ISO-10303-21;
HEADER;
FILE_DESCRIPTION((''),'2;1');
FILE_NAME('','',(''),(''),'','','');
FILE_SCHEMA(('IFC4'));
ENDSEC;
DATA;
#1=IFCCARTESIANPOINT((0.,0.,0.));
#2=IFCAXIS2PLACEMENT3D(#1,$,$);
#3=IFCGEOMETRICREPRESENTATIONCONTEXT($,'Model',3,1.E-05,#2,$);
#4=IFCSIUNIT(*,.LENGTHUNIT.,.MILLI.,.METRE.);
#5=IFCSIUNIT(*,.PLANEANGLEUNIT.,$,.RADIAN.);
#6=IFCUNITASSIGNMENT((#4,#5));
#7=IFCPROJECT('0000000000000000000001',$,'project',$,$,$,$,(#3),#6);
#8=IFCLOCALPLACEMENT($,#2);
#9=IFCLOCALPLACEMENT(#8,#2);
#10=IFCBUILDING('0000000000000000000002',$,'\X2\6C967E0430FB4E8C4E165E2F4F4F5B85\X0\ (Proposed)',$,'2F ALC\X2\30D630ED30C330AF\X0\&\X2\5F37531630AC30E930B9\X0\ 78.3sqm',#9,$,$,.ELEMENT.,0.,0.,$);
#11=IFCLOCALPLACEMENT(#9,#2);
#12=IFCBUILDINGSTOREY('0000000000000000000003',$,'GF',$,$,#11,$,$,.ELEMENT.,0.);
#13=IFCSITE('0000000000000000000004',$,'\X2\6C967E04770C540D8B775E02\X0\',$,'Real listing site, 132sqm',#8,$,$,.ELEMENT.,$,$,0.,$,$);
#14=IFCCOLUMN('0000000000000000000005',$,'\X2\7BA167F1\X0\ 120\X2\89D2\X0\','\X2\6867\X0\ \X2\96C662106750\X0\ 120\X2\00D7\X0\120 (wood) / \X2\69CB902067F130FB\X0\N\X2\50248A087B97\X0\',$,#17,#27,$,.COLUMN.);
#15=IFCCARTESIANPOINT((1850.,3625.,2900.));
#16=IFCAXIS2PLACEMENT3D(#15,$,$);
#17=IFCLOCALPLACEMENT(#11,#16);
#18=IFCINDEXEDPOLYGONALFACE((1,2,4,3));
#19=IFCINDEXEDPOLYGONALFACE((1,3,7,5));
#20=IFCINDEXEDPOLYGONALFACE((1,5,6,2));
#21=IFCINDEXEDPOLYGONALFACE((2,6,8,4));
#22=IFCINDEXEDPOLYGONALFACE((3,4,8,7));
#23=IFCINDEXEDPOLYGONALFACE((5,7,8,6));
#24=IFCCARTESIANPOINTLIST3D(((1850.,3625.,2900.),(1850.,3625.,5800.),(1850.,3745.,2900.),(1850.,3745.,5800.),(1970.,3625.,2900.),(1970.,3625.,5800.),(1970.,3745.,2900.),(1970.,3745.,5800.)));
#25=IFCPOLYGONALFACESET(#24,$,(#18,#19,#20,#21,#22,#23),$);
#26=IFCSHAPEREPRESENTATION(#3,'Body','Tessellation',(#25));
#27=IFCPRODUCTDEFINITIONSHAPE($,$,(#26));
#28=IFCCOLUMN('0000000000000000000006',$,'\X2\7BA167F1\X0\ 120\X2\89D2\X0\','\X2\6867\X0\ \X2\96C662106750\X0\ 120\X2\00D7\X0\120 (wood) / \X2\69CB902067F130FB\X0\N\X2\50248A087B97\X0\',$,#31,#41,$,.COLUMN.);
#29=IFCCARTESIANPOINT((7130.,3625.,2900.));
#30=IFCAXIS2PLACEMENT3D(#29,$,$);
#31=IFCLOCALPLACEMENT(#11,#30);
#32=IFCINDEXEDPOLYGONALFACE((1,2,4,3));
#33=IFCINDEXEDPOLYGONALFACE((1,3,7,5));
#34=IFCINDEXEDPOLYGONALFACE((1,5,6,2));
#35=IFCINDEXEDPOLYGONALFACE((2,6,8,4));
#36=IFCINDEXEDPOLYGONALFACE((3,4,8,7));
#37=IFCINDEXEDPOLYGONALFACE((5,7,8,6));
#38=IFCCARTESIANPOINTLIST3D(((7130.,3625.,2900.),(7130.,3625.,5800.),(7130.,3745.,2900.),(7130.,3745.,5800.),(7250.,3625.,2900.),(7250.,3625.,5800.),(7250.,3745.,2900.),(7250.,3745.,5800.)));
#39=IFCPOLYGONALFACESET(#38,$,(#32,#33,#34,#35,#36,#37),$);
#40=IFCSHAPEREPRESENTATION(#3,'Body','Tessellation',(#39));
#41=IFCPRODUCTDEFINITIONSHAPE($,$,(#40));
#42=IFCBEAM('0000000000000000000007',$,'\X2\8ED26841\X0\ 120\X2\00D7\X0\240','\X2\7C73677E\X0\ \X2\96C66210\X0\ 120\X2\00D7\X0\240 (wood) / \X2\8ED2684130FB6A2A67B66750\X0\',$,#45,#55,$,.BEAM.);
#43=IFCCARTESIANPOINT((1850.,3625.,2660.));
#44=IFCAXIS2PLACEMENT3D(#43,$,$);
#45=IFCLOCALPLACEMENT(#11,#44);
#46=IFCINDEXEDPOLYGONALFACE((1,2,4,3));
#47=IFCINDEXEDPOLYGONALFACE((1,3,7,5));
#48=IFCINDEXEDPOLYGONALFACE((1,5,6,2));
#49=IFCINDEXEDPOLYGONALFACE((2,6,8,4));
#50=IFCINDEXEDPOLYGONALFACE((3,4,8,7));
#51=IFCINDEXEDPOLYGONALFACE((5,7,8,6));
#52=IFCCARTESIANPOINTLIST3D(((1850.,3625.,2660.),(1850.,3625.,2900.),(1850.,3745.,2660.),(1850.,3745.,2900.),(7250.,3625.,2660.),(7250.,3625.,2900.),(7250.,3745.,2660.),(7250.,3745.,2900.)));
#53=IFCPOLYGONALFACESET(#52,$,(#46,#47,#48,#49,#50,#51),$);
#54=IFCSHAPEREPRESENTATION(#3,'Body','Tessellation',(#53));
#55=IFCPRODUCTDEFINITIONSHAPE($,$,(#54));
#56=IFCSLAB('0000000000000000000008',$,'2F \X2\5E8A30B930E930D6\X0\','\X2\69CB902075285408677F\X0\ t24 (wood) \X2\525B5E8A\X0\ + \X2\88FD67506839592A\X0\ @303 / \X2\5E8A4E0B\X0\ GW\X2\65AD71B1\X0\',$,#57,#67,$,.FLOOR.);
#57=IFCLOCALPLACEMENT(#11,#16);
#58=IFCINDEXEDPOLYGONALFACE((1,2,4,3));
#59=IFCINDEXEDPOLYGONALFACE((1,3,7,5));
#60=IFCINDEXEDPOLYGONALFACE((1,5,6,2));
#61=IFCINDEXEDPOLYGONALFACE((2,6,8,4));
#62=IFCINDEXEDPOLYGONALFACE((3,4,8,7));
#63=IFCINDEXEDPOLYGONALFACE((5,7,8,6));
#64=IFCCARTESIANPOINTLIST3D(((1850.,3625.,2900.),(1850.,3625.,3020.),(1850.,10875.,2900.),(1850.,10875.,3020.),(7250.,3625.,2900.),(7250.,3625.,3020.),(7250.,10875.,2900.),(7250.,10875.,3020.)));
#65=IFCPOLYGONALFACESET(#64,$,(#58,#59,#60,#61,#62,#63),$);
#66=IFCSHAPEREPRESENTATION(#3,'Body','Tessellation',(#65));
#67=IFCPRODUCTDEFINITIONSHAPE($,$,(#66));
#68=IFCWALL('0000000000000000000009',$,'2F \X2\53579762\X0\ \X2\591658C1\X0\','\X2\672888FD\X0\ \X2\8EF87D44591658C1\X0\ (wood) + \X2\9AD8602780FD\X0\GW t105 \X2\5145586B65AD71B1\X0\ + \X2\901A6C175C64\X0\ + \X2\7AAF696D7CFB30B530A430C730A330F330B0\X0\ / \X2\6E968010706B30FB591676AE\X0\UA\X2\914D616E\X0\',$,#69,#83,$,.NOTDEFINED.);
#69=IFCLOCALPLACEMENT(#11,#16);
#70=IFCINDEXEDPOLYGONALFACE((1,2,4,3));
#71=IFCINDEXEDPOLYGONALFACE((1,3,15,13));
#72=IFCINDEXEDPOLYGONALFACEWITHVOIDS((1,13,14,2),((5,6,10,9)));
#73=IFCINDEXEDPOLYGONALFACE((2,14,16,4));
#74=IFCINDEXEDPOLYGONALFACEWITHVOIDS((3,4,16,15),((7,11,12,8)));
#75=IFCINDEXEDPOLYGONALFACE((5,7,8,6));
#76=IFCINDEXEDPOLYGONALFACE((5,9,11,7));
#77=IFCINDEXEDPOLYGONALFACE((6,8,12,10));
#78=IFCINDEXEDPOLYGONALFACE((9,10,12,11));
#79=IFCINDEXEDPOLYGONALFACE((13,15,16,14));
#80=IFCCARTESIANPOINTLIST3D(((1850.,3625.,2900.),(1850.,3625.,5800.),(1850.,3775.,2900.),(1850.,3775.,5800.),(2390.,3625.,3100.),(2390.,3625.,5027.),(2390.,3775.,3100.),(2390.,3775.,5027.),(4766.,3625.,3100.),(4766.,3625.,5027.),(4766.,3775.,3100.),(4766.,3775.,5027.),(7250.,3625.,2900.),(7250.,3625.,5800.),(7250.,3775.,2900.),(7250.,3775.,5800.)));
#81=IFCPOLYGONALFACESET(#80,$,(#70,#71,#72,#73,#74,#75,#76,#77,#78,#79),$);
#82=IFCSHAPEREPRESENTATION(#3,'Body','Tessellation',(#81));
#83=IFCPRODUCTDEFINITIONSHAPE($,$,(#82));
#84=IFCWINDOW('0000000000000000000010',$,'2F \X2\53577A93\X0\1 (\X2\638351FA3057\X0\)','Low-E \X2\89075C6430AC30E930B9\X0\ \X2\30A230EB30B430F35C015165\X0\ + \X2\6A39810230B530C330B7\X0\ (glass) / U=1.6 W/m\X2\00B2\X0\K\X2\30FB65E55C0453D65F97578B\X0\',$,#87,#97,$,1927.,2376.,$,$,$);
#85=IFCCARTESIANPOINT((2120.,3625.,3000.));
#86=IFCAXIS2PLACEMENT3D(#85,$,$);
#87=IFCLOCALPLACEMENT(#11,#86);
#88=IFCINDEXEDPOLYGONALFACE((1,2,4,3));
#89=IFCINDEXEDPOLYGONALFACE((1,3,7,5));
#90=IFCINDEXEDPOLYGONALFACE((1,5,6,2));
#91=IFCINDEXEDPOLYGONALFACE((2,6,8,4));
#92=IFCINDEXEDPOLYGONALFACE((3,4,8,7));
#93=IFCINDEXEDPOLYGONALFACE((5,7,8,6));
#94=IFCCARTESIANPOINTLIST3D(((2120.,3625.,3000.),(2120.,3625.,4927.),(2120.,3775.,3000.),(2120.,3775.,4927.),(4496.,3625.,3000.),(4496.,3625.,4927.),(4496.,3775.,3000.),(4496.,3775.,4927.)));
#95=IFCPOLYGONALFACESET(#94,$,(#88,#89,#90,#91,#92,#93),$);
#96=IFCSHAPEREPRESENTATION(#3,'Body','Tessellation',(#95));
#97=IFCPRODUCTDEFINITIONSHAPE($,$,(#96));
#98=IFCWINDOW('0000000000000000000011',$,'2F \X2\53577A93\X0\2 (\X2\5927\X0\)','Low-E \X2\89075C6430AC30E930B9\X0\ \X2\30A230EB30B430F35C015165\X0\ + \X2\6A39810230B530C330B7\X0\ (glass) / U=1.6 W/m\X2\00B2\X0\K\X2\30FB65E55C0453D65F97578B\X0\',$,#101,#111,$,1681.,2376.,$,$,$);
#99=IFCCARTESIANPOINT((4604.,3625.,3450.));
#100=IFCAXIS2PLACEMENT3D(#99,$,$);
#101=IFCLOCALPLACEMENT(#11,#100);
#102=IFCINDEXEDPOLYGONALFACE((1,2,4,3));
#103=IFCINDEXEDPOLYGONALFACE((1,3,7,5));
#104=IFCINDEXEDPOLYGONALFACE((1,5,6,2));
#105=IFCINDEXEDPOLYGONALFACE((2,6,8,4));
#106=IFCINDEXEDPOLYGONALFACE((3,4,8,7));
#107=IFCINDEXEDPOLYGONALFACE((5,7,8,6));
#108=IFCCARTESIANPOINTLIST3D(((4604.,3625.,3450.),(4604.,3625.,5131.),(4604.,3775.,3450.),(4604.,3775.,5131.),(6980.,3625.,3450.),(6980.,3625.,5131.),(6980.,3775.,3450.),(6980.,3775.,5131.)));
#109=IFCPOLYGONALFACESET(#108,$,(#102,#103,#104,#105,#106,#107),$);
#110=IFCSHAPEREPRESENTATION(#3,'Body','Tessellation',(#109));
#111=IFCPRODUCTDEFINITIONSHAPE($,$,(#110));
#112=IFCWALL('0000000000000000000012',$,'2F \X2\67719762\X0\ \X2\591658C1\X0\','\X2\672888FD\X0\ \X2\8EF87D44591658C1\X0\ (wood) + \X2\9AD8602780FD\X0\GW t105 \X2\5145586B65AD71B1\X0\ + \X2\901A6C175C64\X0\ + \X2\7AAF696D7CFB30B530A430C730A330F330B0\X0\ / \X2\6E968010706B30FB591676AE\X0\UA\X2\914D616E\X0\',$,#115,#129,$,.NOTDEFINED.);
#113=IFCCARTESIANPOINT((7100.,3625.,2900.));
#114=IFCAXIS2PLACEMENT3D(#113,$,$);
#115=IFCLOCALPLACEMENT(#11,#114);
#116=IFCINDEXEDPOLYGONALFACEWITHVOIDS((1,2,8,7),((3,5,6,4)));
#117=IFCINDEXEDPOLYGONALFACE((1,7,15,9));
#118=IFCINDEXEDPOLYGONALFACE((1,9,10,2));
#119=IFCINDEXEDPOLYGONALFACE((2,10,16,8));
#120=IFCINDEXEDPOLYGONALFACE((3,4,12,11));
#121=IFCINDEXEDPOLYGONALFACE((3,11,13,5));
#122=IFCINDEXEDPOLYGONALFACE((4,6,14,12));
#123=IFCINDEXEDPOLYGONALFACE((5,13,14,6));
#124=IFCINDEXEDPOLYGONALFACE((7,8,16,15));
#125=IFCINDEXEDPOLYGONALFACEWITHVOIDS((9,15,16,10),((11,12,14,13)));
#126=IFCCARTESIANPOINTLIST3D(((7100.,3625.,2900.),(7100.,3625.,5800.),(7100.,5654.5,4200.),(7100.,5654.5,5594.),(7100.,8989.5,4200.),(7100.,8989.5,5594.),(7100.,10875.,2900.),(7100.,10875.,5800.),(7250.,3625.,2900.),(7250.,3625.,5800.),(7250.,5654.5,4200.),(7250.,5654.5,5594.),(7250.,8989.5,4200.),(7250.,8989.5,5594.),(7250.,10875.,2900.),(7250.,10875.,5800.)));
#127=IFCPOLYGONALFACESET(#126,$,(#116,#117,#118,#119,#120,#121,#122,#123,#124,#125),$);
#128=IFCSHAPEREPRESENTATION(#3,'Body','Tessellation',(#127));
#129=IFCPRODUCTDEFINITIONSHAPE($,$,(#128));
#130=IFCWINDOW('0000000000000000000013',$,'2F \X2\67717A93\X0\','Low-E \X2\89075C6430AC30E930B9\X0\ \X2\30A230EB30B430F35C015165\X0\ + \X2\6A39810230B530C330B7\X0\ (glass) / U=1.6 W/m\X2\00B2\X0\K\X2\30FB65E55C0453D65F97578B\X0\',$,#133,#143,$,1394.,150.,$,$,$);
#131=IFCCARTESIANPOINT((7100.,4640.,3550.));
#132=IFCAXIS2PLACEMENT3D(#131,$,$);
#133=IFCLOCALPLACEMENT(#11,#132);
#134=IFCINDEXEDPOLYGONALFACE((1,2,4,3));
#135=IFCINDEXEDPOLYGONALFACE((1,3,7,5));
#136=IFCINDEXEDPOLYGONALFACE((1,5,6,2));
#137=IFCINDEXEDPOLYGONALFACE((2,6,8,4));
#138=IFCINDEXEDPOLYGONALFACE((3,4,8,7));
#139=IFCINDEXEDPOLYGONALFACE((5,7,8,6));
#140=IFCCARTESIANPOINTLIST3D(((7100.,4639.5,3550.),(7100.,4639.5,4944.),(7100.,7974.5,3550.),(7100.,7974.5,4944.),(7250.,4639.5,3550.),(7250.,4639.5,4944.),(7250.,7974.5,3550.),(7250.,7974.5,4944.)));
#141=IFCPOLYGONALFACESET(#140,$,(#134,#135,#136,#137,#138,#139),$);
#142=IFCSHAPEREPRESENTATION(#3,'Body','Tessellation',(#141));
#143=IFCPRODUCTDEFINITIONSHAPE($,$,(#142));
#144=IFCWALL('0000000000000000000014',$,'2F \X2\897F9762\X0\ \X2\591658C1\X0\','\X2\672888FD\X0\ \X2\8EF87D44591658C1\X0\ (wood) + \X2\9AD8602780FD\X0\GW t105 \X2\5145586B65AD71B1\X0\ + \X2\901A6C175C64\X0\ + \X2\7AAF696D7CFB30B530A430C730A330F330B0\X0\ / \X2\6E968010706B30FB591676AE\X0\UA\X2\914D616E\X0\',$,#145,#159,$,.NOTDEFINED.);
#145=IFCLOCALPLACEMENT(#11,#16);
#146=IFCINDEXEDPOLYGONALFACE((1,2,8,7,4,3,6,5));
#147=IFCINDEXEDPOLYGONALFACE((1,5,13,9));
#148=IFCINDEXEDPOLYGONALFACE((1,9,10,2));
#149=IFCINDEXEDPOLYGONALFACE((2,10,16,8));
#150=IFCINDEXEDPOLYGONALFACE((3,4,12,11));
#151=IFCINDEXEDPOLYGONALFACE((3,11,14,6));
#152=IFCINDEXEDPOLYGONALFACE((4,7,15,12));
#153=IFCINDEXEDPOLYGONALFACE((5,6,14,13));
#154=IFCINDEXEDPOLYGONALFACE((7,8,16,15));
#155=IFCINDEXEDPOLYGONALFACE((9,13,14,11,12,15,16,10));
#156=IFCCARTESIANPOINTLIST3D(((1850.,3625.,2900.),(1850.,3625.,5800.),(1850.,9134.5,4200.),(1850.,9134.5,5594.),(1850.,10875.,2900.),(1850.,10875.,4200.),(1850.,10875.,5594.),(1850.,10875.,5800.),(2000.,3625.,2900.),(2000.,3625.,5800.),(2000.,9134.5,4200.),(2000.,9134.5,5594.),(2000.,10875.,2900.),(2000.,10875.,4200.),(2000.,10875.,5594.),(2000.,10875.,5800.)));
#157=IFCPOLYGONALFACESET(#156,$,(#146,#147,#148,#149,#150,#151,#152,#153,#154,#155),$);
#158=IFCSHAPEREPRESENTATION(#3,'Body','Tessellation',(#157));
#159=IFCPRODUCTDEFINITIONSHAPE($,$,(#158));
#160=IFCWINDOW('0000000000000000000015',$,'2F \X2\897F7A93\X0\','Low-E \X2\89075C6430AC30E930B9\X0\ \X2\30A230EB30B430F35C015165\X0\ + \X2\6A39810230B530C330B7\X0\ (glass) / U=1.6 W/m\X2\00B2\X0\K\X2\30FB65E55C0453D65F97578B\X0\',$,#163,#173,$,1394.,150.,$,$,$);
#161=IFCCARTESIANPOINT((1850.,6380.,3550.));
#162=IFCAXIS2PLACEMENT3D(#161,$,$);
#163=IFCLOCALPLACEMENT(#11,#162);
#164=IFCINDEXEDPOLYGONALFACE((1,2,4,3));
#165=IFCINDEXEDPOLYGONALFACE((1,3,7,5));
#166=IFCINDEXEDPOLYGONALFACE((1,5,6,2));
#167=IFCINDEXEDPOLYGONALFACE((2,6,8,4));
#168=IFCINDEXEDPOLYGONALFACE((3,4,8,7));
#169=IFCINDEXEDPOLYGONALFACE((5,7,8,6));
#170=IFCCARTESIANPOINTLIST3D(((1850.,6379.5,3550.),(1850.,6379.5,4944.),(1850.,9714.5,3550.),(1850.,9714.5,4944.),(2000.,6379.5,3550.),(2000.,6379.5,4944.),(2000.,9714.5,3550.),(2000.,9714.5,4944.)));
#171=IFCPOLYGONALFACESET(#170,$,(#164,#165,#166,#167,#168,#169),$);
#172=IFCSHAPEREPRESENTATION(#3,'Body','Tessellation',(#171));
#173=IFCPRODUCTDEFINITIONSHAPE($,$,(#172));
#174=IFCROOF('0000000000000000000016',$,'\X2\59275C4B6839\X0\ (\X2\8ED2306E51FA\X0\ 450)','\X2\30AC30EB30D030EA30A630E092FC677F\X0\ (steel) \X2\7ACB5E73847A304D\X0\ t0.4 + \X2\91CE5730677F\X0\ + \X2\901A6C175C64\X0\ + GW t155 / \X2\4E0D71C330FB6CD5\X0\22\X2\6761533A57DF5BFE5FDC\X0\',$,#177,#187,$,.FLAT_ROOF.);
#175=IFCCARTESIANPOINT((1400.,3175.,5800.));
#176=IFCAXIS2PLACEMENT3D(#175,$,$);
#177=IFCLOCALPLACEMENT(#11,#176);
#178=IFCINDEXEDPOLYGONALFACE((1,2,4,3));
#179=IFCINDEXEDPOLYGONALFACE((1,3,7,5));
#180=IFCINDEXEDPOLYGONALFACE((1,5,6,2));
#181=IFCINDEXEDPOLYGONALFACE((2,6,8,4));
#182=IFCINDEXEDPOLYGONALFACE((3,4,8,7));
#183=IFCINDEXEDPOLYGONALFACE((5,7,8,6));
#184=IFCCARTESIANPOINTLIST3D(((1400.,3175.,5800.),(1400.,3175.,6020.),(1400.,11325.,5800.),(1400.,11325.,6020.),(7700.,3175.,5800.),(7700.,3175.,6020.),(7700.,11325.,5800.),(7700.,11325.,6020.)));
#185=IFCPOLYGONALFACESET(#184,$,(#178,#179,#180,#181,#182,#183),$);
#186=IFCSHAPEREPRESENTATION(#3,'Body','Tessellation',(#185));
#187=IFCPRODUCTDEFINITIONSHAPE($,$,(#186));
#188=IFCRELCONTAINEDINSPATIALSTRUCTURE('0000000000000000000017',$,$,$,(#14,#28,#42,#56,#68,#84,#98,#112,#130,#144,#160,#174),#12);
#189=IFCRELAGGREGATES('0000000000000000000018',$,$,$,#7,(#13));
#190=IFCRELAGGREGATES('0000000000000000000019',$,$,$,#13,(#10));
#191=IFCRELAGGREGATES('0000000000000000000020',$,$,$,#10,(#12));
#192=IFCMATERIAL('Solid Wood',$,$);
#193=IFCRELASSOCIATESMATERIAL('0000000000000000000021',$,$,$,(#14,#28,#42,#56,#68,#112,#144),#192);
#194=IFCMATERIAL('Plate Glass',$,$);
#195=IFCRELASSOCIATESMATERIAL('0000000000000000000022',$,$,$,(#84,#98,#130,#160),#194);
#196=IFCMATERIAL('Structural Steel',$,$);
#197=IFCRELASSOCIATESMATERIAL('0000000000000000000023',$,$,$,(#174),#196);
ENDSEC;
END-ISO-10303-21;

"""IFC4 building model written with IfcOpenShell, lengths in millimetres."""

from ifc_helpers import new_model, si_unit, frame, frame_2d, origin, place, context, project, spatial, rectangle, extrude, material, element, fill, save


model = new_model("IFC4")

# Units and contexts
model_context = context("Model", 3, precision=1e-05, world=origin())
ifc_project = project(units=[si_unit("LENGTHUNIT", "METRE", prefix="MILLI"), si_unit("PLANEANGLEUNIT", "RADIAN")], contexts=[model_context])

# Site, building, storey
site_placement = place(None, origin())
site = spatial("IfcSite", under=ifc_project, at=site_placement, Name="沖縄県名護市", ObjectType="Real listing site, 132sqm", CompositionType="ELEMENT", RefElevation=0.0)
building_placement = place(site_placement, origin())
building = spatial("IfcBuilding", under=site, at=building_placement, Name="沖縄・二世帯住宅 (Proposed)", ObjectType="2F ALCブロック&強化ガラス 78.3sqm", CompositionType="ELEMENT", ElevationOfRefHeight=0.0, ElevationOfTerrain=0.0)
storey_placement = place(building_placement, origin())
storey = spatial("IfcBuildingStorey", under=building, at=storey_placement, Name="GF", CompositionType="ELEMENT", Elevation=0.0)

# Columns
ifc_material_1 = material(Name="Solid Wood")
column_1_placement = place(storey_placement, frame((1850.0, 3625.0, 2900.0)))
element("IfcColumn", 1, at=column_1_placement, inside=storey, material=ifc_material_1, Name="管柱 120角", Description="桧 集成材 120×120 (wood) / 構造柱・N値計算", PredefinedType="COLUMN", context=model_context, shape_type="SweptSolid", body=[
    extrude(rectangle(XDim=120.0, YDim=120.0, at=frame_2d((60.0, 60.0))), frame((1850.0, 3625.0, 2900.0)), (0.0, 0.0, 1.0), 2900.0),
])
column_2_placement = place(storey_placement, frame((7130.0, 3625.0, 2900.0)))
element("IfcColumn", 2, at=column_2_placement, inside=storey, material=ifc_material_1, Name="管柱 120角", Description="桧 集成材 120×120 (wood) / 構造柱・N値計算", PredefinedType="COLUMN", context=model_context, shape_type="SweptSolid", body=[
    extrude(rectangle(XDim=120.0, YDim=120.0, at=frame_2d((60.0, 60.0))), frame((7130.0, 3625.0, 2900.0)), (0.0, 0.0, 1.0), 2900.0),
])

# Beam
beam_1_placement = place(storey_placement, frame((1850.0, 3625.0, 2660.0)))
element("IfcBeam", 3, at=beam_1_placement, inside=storey, material=ifc_material_1, Name="軒桁 120×240", Description="米松 集成 120×240 (wood) / 軒桁・横架材", PredefinedType="BEAM", context=model_context, shape_type="SweptSolid", body=[
    extrude(rectangle(XDim=5400.0, YDim=120.0, at=frame_2d((2700.0, 60.0))), frame((1850.0, 3625.0, 2660.0)), (0.0, 0.0, 1.0), 240.0),
])

# Slab
slab_placement = place(storey_placement, frame((1850.0, 3625.0, 2900.0)))
element("IfcSlab", 4, at=slab_placement, inside=storey, material=ifc_material_1, Name="2F 床スラブ", Description="構造用合板 t24 (wood) 剛床 + 製材根太 @303 / 床下 GW断熱", PredefinedType="FLOOR", context=model_context, shape_type="SweptSolid", body=[
    extrude(rectangle(XDim=5400.0, YDim=7250.0, at=frame_2d((2700.0, 3625.0))), frame((1850.0, 3625.0, 2900.0)), (0.0, 0.0, 1.0), 120.0),
])

# Wall, openings, windows
wall_1_placement = place(storey_placement, frame((1850.0, 3625.0, 2900.0)))
wall_1 = element("IfcWall", 5, at=wall_1_placement, inside=storey, material=ifc_material_1, Name="2F 南面 外壁", Description="木製 軸組外壁 (wood) + 高性能GW t105 充填断熱 + 通気層 + 窯業系サイディング / 準耐火・外皮UA配慮", PredefinedType="NOTDEFINED", context=model_context, shape_type="SweptSolid", body=[
    extrude(rectangle(XDim=5400.0, YDim=150.0, at=frame_2d((2700.0, 75.0))), frame((1850.0, 3625.0, 2900.0)), (0.0, 0.0, 1.0), 2900.0),
])
opening_1_placement = place(storey_placement, frame((2120.0, 3625.0, 3000.0)))
opening_1 = element("IfcOpeningElement", 6, at=opening_1_placement, cuts=wall_1, PredefinedType="NOTDEFINED", context=model_context, shape_type="SweptSolid", body=[
    extrude(rectangle(XDim=2376.0, YDim=150.0, at=frame_2d((1188.0, 75.0))), frame((2120.0, 3625.0, 3000.0)), (0.0, 0.0, 1.0), 1927.0),
])
opening_2_placement = place(storey_placement, frame((4604.0, 3625.0, 3450.0)))
opening_2 = element("IfcOpeningElement", 7, at=opening_2_placement, cuts=wall_1, PredefinedType="NOTDEFINED", context=model_context, shape_type="SweptSolid", body=[
    extrude(rectangle(XDim=2376.0, YDim=150.0, at=frame_2d((1188.0, 75.0))), frame((4604.0, 3625.0, 3450.0)), (0.0, 0.0, 1.0), 1681.0),
])
ifc_material_2 = material(Name="Plate Glass")
window_1_placement = place(storey_placement, frame((2120.0, 3625.0, 3000.0)))
window_1 = element("IfcWindow", 8, at=window_1_placement, inside=storey, material=ifc_material_2, Name="2F 南窓1 (掃出し)", Description="Low-E 複層ガラス アルゴン封入 + 樹脂サッシ (glass) / U=1.6 W/m²K・日射取得型", OverallHeight=1927.0, OverallWidth=2376.0, context=model_context, shape_type="SweptSolid", body=[
    extrude(rectangle(XDim=2376.0, YDim=150.0, at=frame_2d((1188.0, 75.0))), frame((2120.0, 3625.0, 3000.0)), (0.0, 0.0, 1.0), 1927.0),
])
fill(opening_1, window_1)
window_2_placement = place(storey_placement, frame((4604.0, 3625.0, 3450.0)))
window_2 = element("IfcWindow", 9, at=window_2_placement, inside=storey, material=ifc_material_2, Name="2F 南窓2 (大)", Description="Low-E 複層ガラス アルゴン封入 + 樹脂サッシ (glass) / U=1.6 W/m²K・日射取得型", OverallHeight=1681.0, OverallWidth=2376.0, context=model_context, shape_type="SweptSolid", body=[
    extrude(rectangle(XDim=2376.0, YDim=150.0, at=frame_2d((1188.0, 75.0))), frame((4604.0, 3625.0, 3450.0)), (0.0, 0.0, 1.0), 1681.0),
])
fill(opening_2, window_2)

# Walls, openings, windows
wall_2_placement = place(storey_placement, frame((7100.0, 3625.0, 2900.0)))
wall_2 = element("IfcWall", 10, at=wall_2_placement, inside=storey, material=ifc_material_1, Name="2F 東面 外壁", Description="木製 軸組外壁 (wood) + 高性能GW t105 充填断熱 + 通気層 + 窯業系サイディング / 準耐火・外皮UA配慮", PredefinedType="NOTDEFINED", context=model_context, shape_type="SweptSolid", body=[
    extrude(rectangle(XDim=150.0, YDim=7250.0, at=frame_2d((75.0, 3625.0))), frame((7100.0, 3625.0, 2900.0)), (0.0, 0.0, 1.0), 2900.0),
])
opening_3_placement = place(storey_placement, frame((7100.0, 4640.0, 3550.0)))
opening_3 = element("IfcOpeningElement", 11, at=opening_3_placement, cuts=wall_2, PredefinedType="NOTDEFINED", context=model_context, shape_type="SweptSolid", body=[
    extrude(rectangle(XDim=150.0, YDim=3335.0, at=frame_2d((75.0, 1667.0))), frame((7100.0, 4640.0, 3550.0)), (0.0, 0.0, 1.0), 1394.0),
])
window_3_placement = place(storey_placement, frame((7100.0, 4640.0, 3550.0)))
window_3 = element("IfcWindow", 12, at=window_3_placement, inside=storey, material=ifc_material_2, Name="2F 東窓", Description="Low-E 複層ガラス アルゴン封入 + 樹脂サッシ (glass) / U=1.6 W/m²K・日射取得型", OverallHeight=1394.0, OverallWidth=150.0, context=model_context, shape_type="SweptSolid", body=[
    extrude(rectangle(XDim=150.0, YDim=3335.0, at=frame_2d((75.0, 1667.0))), frame((7100.0, 4640.0, 3550.0)), (0.0, 0.0, 1.0), 1394.0),
])
fill(opening_3, window_3)
wall_3_placement = place(storey_placement, frame((1850.0, 3625.0, 2900.0)))
wall_3 = element("IfcWall", 13, at=wall_3_placement, inside=storey, material=ifc_material_1, Name="2F 西面 外壁", Description="木製 軸組外壁 (wood) + 高性能GW t105 充填断熱 + 通気層 + 窯業系サイディング / 準耐火・外皮UA配慮", PredefinedType="NOTDEFINED", context=model_context, shape_type="SweptSolid", body=[
    extrude(rectangle(XDim=150.0, YDim=7250.0, at=frame_2d((75.0, 3625.0))), frame((1850.0, 3625.0, 2900.0)), (0.0, 0.0, 1.0), 2900.0),
])
opening_4_placement = place(storey_placement, frame((1850.0, 6380.0, 3550.0)))
opening_4 = element("IfcOpeningElement", 14, at=opening_4_placement, cuts=wall_3, PredefinedType="NOTDEFINED", context=model_context, shape_type="SweptSolid", body=[
    extrude(rectangle(XDim=150.0, YDim=3335.0, at=frame_2d((75.0, 1667.0))), frame((1850.0, 6380.0, 3550.0)), (0.0, 0.0, 1.0), 1394.0),
])
window_4_placement = place(storey_placement, frame((1850.0, 6380.0, 3550.0)))
window_4 = element("IfcWindow", 15, at=window_4_placement, inside=storey, material=ifc_material_2, Name="2F 西窓", Description="Low-E 複層ガラス アルゴン封入 + 樹脂サッシ (glass) / U=1.6 W/m²K・日射取得型", OverallHeight=1394.0, OverallWidth=150.0, context=model_context, shape_type="SweptSolid", body=[
    extrude(rectangle(XDim=150.0, YDim=3335.0, at=frame_2d((75.0, 1667.0))), frame((1850.0, 6380.0, 3550.0)), (0.0, 0.0, 1.0), 1394.0),
])
fill(opening_4, window_4)

# Roof
ifc_material_3 = material(Name="Structural Steel")
roof_placement = place(storey_placement, frame((1400.0, 3175.0, 5800.0)))
element("IfcRoof", 16, at=roof_placement, inside=storey, material=ifc_material_3, Name="大屋根 (軒の出 450)", Description="ガルバリウム鋼板 (steel) 立平葺き t0.4 + 野地板 + 通気層 + GW t155 / 不燃・法22条区域対応", PredefinedType="FLAT_ROOF", context=model_context, shape_type="SweptSolid", body=[
    extrude(rectangle(XDim=6300.0, YDim=8150.0, at=frame_2d((3150.0, 4075.0))), frame((1400.0, 3175.0, 5800.0)), (0.0, 0.0, 1.0), 220.0),
])

save(model, "model.ifc")
